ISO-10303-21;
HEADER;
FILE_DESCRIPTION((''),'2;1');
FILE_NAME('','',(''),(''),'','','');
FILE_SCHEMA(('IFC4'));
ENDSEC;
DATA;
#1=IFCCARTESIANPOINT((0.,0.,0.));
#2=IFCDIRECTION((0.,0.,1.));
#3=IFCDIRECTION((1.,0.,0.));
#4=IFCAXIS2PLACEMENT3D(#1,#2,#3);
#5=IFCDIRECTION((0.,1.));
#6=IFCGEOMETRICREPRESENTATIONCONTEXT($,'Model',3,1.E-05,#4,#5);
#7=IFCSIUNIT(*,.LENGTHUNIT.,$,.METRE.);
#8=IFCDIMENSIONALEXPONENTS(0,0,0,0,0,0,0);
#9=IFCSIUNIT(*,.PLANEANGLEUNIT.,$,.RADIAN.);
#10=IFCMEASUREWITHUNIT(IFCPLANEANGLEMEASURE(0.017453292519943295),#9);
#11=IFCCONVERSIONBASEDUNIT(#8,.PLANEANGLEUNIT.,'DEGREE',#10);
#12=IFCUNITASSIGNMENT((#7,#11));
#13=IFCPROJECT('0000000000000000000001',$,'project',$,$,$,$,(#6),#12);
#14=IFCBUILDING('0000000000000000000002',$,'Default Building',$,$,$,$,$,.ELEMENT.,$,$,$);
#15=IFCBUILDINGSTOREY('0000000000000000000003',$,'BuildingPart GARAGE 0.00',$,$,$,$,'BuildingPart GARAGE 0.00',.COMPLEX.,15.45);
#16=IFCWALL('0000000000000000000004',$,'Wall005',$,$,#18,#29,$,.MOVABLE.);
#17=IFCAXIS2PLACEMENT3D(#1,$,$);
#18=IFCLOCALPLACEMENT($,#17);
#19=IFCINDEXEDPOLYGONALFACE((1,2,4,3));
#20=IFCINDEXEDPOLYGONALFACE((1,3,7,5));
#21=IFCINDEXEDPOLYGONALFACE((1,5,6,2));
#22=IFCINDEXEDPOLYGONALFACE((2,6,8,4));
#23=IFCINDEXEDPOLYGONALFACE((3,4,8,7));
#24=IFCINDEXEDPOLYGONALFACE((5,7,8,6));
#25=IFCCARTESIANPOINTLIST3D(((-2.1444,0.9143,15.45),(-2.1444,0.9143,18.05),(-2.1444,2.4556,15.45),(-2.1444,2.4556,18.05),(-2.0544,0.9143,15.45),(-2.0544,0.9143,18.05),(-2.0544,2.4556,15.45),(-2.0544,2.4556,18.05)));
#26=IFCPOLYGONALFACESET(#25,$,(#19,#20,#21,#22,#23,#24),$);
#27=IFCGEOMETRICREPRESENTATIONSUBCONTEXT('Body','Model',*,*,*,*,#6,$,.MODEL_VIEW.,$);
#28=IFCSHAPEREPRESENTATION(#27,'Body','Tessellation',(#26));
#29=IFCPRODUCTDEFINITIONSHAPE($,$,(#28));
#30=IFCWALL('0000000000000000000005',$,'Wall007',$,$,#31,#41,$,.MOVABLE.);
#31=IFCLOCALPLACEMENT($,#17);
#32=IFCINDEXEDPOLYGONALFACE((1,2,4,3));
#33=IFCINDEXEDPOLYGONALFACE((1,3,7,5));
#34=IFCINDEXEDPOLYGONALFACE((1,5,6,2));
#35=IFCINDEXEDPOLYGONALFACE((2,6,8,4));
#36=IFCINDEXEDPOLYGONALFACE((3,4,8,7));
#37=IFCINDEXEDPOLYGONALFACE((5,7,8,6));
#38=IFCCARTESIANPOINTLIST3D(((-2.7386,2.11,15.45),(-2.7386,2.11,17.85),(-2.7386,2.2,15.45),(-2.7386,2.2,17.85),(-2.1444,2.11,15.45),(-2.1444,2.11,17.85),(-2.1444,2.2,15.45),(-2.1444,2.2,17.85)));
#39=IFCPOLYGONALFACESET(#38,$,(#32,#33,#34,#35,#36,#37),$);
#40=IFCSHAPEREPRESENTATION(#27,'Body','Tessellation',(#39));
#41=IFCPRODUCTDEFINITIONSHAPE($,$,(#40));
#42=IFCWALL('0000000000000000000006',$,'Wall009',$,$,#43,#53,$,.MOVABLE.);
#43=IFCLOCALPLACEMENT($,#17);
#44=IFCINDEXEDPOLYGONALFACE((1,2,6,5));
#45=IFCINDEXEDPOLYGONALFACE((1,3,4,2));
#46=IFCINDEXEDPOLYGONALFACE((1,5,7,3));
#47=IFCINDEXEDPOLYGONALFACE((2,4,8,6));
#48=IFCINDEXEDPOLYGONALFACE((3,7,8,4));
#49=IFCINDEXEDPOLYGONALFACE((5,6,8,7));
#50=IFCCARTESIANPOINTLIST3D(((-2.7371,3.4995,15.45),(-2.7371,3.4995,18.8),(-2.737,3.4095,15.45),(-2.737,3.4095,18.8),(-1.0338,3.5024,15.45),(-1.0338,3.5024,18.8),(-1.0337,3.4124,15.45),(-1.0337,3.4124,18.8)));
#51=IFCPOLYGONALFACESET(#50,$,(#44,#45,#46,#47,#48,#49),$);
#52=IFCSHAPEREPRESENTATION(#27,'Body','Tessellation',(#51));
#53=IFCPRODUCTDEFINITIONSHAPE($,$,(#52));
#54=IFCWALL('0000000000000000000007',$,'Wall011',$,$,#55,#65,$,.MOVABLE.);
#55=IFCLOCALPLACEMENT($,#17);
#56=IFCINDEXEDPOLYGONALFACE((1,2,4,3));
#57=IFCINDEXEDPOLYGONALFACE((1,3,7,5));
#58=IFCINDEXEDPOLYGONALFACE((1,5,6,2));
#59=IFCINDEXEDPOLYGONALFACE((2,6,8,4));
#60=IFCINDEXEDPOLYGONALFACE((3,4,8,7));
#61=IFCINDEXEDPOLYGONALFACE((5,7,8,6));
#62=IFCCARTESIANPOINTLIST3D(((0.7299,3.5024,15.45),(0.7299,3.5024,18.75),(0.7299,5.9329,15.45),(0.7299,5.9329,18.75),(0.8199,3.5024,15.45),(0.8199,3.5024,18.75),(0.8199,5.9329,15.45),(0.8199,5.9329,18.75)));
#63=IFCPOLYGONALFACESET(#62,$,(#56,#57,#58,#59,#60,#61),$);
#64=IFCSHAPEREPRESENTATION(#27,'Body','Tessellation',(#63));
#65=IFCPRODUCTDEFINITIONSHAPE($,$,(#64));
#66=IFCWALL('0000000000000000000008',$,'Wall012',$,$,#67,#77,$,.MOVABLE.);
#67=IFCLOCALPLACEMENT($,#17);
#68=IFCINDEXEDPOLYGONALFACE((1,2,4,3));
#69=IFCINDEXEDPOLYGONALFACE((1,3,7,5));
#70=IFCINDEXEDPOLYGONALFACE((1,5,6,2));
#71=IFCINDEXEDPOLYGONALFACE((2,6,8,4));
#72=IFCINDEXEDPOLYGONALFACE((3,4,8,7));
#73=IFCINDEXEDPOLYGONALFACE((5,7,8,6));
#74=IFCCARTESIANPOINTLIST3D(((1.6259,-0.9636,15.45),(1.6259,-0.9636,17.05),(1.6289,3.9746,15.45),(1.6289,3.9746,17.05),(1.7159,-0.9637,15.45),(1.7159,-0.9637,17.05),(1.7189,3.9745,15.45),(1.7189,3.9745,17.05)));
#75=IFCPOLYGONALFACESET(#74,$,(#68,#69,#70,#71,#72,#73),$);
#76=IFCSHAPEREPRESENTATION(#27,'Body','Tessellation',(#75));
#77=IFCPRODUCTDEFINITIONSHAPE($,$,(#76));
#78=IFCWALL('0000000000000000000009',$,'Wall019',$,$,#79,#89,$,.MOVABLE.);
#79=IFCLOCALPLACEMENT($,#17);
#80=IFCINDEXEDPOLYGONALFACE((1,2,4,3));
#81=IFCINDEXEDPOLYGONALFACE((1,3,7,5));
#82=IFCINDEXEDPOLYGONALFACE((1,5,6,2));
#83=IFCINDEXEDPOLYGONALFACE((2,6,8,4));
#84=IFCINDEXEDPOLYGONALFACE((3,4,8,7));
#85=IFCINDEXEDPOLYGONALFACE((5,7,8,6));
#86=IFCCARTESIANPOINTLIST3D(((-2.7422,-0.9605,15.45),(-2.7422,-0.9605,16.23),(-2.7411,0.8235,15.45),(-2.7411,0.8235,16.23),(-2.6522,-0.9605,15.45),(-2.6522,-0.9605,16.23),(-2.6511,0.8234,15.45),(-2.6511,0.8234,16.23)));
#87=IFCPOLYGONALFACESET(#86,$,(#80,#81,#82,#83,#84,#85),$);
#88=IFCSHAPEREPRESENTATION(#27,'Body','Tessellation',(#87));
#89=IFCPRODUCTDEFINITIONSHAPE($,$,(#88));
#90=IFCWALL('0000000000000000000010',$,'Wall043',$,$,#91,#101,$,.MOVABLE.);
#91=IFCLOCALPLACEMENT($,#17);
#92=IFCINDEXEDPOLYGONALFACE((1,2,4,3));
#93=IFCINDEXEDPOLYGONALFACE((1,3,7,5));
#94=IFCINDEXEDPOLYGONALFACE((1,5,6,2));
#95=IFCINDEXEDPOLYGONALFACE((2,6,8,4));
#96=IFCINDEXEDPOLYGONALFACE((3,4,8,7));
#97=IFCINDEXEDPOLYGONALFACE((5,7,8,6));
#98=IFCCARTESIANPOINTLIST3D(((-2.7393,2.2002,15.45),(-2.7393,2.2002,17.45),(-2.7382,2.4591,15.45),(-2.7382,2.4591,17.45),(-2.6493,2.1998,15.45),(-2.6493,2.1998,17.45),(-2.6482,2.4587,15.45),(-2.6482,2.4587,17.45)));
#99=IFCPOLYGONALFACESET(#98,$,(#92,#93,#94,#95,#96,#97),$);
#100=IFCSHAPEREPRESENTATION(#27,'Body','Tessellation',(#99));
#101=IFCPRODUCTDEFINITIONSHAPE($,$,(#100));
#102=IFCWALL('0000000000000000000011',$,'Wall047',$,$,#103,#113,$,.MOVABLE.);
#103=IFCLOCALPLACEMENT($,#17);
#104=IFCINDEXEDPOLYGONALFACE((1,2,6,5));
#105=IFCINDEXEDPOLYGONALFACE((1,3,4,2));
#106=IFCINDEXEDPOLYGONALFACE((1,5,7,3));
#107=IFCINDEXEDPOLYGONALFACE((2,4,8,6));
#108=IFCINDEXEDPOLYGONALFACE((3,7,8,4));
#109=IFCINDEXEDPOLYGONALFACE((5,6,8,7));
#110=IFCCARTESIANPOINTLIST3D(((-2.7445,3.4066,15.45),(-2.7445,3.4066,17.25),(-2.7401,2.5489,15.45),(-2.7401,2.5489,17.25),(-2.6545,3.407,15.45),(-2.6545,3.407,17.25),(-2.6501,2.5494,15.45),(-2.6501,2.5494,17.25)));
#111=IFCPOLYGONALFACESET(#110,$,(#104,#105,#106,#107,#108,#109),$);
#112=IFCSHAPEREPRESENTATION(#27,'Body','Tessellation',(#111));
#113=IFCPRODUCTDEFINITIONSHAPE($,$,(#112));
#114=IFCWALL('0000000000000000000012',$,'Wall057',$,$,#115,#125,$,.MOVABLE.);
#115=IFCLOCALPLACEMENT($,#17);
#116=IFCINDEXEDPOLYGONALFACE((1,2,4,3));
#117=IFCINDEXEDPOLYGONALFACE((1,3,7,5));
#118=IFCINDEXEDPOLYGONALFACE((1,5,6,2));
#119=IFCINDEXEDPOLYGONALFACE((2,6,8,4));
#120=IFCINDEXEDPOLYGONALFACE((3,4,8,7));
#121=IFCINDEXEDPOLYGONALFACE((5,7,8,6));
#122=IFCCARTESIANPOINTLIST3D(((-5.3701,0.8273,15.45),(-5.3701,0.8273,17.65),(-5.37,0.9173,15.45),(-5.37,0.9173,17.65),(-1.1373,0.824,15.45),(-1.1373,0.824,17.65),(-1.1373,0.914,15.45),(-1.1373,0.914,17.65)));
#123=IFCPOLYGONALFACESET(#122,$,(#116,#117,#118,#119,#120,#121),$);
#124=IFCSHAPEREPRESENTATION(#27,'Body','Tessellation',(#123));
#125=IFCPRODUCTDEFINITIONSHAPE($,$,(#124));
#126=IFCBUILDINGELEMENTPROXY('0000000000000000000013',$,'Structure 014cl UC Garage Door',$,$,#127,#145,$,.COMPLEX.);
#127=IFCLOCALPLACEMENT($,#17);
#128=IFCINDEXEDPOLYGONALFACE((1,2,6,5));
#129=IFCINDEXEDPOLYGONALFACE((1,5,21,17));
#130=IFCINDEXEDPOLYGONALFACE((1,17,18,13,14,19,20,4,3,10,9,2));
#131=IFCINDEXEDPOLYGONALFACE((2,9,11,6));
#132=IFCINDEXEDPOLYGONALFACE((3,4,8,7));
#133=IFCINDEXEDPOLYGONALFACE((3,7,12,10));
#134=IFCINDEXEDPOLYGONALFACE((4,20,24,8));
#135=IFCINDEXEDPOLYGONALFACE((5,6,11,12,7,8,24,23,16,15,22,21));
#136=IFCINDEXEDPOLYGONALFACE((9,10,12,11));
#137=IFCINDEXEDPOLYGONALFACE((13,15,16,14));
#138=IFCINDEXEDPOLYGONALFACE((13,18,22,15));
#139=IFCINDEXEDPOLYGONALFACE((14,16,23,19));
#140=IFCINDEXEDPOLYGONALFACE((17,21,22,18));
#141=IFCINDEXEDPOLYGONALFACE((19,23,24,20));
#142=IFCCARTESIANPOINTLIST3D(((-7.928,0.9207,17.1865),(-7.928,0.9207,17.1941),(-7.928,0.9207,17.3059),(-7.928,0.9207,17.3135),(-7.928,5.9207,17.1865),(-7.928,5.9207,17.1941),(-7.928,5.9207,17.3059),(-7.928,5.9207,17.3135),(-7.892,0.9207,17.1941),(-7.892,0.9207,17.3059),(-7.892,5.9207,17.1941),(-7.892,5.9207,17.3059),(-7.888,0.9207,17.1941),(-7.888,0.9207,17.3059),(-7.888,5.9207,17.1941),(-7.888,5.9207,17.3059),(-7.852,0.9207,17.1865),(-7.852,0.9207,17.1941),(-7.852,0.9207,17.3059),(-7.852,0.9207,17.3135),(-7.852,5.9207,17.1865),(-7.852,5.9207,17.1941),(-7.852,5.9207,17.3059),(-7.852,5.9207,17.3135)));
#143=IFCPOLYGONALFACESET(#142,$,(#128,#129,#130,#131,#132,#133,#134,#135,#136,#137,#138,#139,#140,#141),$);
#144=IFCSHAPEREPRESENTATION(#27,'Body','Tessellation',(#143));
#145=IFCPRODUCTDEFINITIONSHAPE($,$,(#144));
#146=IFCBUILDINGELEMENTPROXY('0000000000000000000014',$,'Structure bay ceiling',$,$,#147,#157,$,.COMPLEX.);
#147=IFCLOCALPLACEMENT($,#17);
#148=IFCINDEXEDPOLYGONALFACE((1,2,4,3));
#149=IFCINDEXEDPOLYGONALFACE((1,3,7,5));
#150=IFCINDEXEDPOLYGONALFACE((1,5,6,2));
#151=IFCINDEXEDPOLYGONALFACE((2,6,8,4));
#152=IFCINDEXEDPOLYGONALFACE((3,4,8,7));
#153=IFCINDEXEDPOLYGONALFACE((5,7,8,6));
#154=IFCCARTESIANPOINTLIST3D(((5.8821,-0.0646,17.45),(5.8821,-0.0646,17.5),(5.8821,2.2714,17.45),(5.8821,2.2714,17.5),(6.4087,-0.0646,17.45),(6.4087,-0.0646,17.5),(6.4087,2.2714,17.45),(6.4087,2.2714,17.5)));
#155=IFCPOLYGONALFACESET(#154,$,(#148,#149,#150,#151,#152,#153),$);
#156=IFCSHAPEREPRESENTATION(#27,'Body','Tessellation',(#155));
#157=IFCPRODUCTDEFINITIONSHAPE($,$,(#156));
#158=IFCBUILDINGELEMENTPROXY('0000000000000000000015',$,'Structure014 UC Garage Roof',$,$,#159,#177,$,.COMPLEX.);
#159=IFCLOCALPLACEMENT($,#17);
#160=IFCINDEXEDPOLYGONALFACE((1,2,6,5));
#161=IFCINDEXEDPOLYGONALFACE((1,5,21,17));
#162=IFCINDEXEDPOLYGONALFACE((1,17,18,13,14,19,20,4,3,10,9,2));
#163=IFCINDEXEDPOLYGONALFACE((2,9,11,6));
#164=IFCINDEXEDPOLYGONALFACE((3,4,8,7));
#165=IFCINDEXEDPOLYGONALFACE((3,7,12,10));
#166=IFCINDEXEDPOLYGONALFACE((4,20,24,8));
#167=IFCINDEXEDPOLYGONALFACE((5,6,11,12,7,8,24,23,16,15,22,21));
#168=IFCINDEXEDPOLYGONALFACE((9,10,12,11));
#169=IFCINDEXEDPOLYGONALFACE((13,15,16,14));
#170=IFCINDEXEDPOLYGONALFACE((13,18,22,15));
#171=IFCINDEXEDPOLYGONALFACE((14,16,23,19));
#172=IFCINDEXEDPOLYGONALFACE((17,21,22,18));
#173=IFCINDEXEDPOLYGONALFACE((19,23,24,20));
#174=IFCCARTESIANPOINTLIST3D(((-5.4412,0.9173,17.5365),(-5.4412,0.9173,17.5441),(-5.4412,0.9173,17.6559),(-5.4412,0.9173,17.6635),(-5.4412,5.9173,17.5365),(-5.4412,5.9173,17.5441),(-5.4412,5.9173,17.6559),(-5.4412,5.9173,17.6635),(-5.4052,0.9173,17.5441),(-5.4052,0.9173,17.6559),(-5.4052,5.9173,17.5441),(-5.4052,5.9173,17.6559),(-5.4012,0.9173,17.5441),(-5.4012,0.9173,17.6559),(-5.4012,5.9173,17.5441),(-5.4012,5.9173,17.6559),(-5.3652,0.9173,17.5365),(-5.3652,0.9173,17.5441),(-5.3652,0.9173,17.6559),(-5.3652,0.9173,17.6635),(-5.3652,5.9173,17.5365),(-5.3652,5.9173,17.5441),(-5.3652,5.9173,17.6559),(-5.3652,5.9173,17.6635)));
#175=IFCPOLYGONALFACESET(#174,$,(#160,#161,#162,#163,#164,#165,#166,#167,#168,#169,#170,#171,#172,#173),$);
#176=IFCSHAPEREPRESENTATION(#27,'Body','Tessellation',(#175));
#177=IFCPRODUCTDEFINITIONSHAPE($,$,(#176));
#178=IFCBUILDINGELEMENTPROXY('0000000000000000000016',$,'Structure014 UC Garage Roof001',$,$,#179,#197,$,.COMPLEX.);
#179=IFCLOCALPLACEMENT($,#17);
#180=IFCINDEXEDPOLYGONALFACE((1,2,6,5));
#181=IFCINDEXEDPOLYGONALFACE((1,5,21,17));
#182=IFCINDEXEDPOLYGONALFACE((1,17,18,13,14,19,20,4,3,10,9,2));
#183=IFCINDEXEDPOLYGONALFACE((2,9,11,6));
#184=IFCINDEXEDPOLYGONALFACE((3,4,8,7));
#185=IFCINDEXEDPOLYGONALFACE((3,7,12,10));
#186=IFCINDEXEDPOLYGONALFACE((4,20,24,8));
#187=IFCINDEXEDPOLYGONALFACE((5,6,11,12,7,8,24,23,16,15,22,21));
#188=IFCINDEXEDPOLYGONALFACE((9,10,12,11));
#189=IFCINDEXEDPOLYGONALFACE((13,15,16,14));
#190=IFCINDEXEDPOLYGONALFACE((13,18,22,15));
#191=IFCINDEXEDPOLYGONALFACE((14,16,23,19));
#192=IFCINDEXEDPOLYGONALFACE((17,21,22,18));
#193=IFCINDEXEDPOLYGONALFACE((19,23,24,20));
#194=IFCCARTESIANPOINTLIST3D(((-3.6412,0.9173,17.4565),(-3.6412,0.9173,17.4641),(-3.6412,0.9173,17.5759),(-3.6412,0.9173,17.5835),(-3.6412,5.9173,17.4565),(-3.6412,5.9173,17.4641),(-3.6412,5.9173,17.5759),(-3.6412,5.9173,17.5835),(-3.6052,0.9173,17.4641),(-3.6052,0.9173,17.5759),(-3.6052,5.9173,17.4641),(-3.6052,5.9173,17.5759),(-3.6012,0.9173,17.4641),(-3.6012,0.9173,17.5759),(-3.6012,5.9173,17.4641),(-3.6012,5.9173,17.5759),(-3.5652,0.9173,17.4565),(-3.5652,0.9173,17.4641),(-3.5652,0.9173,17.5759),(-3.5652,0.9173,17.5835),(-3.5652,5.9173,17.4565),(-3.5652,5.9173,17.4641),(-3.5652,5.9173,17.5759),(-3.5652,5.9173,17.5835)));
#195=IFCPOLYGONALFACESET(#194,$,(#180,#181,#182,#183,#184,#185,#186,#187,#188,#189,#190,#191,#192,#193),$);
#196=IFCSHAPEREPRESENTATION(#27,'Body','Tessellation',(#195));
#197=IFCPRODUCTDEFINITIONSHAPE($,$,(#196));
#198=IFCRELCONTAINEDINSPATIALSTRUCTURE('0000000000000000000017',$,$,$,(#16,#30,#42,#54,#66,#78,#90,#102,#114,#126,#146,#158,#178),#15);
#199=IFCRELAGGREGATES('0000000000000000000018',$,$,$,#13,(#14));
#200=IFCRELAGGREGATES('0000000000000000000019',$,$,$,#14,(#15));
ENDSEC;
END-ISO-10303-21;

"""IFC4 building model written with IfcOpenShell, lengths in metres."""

from ifc_helpers import new_model, entity, si_unit, converted_unit, direction, frame, frame_2d, origin_with_axes, origin_2d_with_axis, place, context, subcontext, project, spatial, polyline, rectangle, outline, extrude, element, save


model = new_model("IFC4")

# Units and contexts
model_context = context("Model", 3, precision=1e-05, world=origin_with_axes(), true_north=direction((0.0, 1.0)))
body_context = subcontext(model_context, "Body", "Model", "MODEL_VIEW")
ifc_project = project(units=[si_unit("LENGTHUNIT", "METRE"), converted_unit("PLANEANGLEUNIT", "DEGREE", entity("IfcPlaneAngleMeasure", 0.017453292519943295), si_unit("PLANEANGLEUNIT", "RADIAN"), dimensions=[0, 0, 0, 0, 0, 0, 0])], contexts=[model_context])

# Building, storey
building = spatial("IfcBuilding", under=ifc_project, Name="Default Building", CompositionType="ELEMENT")
storey = spatial("IfcBuildingStorey", under=building, Name="BuildingPart GARAGE 0.00", LongName="BuildingPart GARAGE 0.00", CompositionType="COMPLEX", Elevation=15.45)

# Walls
placement = place(None, origin_with_axes())
element("IfcWall", 1, at=placement, inside=storey, Name="Wall005", PredefinedType="MOVABLE", context=body_context, shape_type="SweptSolid", body=[
    extrude(rectangle(XDim=1.5413, YDim=0.09, at=frame_2d((0.0, 0.0), x_axis=(0.0, 1.0))), frame((-2.0994, 1.6849, 15.45), z_axis=(0.0, 0.0, 1.0), x_axis=(1.0, 0.0, 0.0)), (0.0, 0.0, 1.0), 2.6),
])
element("IfcWall", 2, at=placement, inside=storey, Name="Wall007", PredefinedType="MOVABLE", context=body_context, shape_type="SweptSolid", body=[
    extrude(rectangle(XDim=0.5942, YDim=0.09, at=frame_2d((0.0, 0.0), x_axis=(-1.0, 0.0))), frame((-2.4415, 2.155, 15.45), z_axis=(0.0, 0.0, 1.0), x_axis=(1.0, 0.0, 0.0)), (0.0, 0.0, 1.0), 2.4),
])
element("IfcWall", 3, at=placement, inside=storey, Name="Wall009", PredefinedType="MOVABLE", context=body_context, shape_type="SweptSolid", body=[
    extrude(rectangle(XDim=1.7033, YDim=0.09, at=frame_2d((0.0, 0.0), x_axis=(0.999999, 0.001656))), frame((-1.8854, 3.4559, 15.45), z_axis=(0.0, 0.0, 1.0), x_axis=(1.0, 0.0, 0.0)), (0.0, 0.0, 1.0), 3.35),
])
element("IfcWall", 4, at=placement, inside=storey, Name="Wall011", PredefinedType="MOVABLE", context=body_context, shape_type="SweptSolid", body=[
    extrude(rectangle(XDim=2.4306, YDim=0.09, at=frame_2d((0.0, 0.0), x_axis=(0.0, -1.0))), frame((0.7749, 4.7176, 15.45), z_axis=(0.0, 0.0, 1.0), x_axis=(1.0, 0.0, 0.0)), (0.0, 0.0, 1.0), 3.3),
])
element("IfcWall", 5, at=placement, inside=storey, Name="Wall012", PredefinedType="MOVABLE", context=body_context, shape_type="SweptSolid", body=[
    extrude(rectangle(XDim=4.9382, YDim=0.09, at=frame_2d((0.0, 0.0), x_axis=(-0.000599, -1.0))), frame((1.6724, 1.5055, 15.45), z_axis=(0.0, 0.0, 1.0), x_axis=(1.0, 0.0, 0.0)), (0.0, 0.0, 1.0), 1.6),
])
element("IfcWall", 6, at=placement, inside=storey, Name="Wall019", PredefinedType="MOVABLE", context=body_context, shape_type="SweptSolid", body=[
    extrude(rectangle(XDim=1.784, YDim=0.09, at=frame_2d((0.0, 0.0), x_axis=(-0.000602, -1.0))), frame((-2.6967, -0.0685, 15.45), z_axis=(0.0, 0.0, 1.0), x_axis=(1.0, 0.0, 0.0)), (0.0, 0.0, 1.0), 0.78),
])
element("IfcWall", 7, at=placement, inside=storey, Name="Wall043", PredefinedType="MOVABLE", context=body_context, shape_type="SweptSolid", body=[
    extrude(rectangle(XDim=0.2589, YDim=0.09, at=frame_2d((0.0, 0.0), x_axis=(-0.004471, -0.99999))), frame((-2.6938, 2.3295, 15.45), z_axis=(0.0, 0.0, 1.0), x_axis=(1.0, 0.0, 0.0)), (0.0, 0.0, 1.0), 2.0),
])

# Walls
element("IfcWall", 8, at=placement, inside=storey, Name="Wall047", PredefinedType="MOVABLE", context=body_context, shape_type="SweptSolid", body=[
    extrude(rectangle(XDim=0.8577, YDim=0.09, at=frame_2d((0.0, 0.0), x_axis=(0.005114, -0.999987))), frame((-2.6973, 2.978, 15.45), z_axis=(0.0, 0.0, 1.0), x_axis=(1.0, 0.0, 0.0)), (0.0, 0.0, 1.0), 1.8),
])
element("IfcWall", 9, at=placement, inside=storey, Name="Wall057", PredefinedType="MOVABLE", context=body_context, shape_type="SweptSolid", body=[
    extrude(rectangle(XDim=4.2328, YDim=0.09, at=frame_2d((0.0, 0.0), x_axis=(1.0, -0.000764))), frame((-3.2537, 0.8706, 15.45), z_axis=(0.0, 0.0, 1.0), x_axis=(1.0, 0.0, 0.0)), (0.0, 0.0, 1.0), 2.2),
])

# Building element proxies
element("IfcBuildingElementProxy", 10, at=placement, inside=storey, Name="Structure 014cl UC Garage Door", PredefinedType="COMPLEX", context=body_context, shape_type="SweptSolid", body=[
    extrude(outline(polyline([(-0.038, -0.0635), (0.038, -0.0635), (0.038, -0.0559), (0.002, -0.0559), (0.002, 0.0559), (0.038, 0.0559), (0.038, 0.0635), (-0.038, 0.0635), (-0.038, 0.0559), (-0.002, 0.0559), (-0.002, -0.0559), (-0.038, -0.0559), (-0.038, -0.0635)])), frame((-7.89, 0.9207, 17.25), z_axis=(0.0, 1.0, 0.0), x_axis=(1.0, 0.0, 0.0)), (0.0, 0.0, 1.0), 5.0),
])
element("IfcBuildingElementProxy", 11, at=placement, inside=storey, Name="Structure bay ceiling", PredefinedType="COMPLEX", context=body_context, shape_type="SweptSolid", body=[
    extrude(rectangle(XDim=0.5266, YDim=2.336, at=origin_2d_with_axis()), frame((6.1454, 1.1034, 17.45), z_axis=(0.0, 0.0, 1.0), x_axis=(1.0, 0.0, 0.0)), (0.0, 0.0, 1.0), 0.05),
])
element("IfcBuildingElementProxy", 12, at=placement, inside=storey, Name="Structure014 UC Garage Roof", PredefinedType="COMPLEX", context=body_context, shape_type="SweptSolid", body=[
    extrude(outline(polyline([(-0.038, -0.0635), (0.038, -0.0635), (0.038, -0.0559), (0.002, -0.0559), (0.002, 0.0559), (0.038, 0.0559), (0.038, 0.0635), (-0.038, 0.0635), (-0.038, 0.0559), (-0.002, 0.0559), (-0.002, -0.0559), (-0.038, -0.0559), (-0.038, -0.0635)])), frame((-5.4032, 0.9173, 17.6), z_axis=(0.0, 1.0, 0.0), x_axis=(1.0, 0.0, 0.0)), (0.0, 0.0, 1.0), 5.0),
])
element("IfcBuildingElementProxy", 13, at=placement, inside=storey, Name="Structure014 UC Garage Roof001", PredefinedType="COMPLEX", context=body_context, shape_type="SweptSolid", body=[
    extrude(outline(polyline([(-0.038, -0.0635), (0.038, -0.0635), (0.038, -0.0559), (0.002, -0.0559), (0.002, 0.0559), (0.038, 0.0559), (0.038, 0.0635), (-0.038, 0.0635), (-0.038, 0.0559), (-0.002, 0.0559), (-0.002, -0.0559), (-0.038, -0.0559), (-0.038, -0.0635)])), frame((-3.6032, 0.9173, 17.52), z_axis=(0.0, 1.0, 0.0), x_axis=(1.0, 0.0, 0.0)), (0.0, 0.0, 1.0), 5.0),
])

save(model, "model.ifc")
